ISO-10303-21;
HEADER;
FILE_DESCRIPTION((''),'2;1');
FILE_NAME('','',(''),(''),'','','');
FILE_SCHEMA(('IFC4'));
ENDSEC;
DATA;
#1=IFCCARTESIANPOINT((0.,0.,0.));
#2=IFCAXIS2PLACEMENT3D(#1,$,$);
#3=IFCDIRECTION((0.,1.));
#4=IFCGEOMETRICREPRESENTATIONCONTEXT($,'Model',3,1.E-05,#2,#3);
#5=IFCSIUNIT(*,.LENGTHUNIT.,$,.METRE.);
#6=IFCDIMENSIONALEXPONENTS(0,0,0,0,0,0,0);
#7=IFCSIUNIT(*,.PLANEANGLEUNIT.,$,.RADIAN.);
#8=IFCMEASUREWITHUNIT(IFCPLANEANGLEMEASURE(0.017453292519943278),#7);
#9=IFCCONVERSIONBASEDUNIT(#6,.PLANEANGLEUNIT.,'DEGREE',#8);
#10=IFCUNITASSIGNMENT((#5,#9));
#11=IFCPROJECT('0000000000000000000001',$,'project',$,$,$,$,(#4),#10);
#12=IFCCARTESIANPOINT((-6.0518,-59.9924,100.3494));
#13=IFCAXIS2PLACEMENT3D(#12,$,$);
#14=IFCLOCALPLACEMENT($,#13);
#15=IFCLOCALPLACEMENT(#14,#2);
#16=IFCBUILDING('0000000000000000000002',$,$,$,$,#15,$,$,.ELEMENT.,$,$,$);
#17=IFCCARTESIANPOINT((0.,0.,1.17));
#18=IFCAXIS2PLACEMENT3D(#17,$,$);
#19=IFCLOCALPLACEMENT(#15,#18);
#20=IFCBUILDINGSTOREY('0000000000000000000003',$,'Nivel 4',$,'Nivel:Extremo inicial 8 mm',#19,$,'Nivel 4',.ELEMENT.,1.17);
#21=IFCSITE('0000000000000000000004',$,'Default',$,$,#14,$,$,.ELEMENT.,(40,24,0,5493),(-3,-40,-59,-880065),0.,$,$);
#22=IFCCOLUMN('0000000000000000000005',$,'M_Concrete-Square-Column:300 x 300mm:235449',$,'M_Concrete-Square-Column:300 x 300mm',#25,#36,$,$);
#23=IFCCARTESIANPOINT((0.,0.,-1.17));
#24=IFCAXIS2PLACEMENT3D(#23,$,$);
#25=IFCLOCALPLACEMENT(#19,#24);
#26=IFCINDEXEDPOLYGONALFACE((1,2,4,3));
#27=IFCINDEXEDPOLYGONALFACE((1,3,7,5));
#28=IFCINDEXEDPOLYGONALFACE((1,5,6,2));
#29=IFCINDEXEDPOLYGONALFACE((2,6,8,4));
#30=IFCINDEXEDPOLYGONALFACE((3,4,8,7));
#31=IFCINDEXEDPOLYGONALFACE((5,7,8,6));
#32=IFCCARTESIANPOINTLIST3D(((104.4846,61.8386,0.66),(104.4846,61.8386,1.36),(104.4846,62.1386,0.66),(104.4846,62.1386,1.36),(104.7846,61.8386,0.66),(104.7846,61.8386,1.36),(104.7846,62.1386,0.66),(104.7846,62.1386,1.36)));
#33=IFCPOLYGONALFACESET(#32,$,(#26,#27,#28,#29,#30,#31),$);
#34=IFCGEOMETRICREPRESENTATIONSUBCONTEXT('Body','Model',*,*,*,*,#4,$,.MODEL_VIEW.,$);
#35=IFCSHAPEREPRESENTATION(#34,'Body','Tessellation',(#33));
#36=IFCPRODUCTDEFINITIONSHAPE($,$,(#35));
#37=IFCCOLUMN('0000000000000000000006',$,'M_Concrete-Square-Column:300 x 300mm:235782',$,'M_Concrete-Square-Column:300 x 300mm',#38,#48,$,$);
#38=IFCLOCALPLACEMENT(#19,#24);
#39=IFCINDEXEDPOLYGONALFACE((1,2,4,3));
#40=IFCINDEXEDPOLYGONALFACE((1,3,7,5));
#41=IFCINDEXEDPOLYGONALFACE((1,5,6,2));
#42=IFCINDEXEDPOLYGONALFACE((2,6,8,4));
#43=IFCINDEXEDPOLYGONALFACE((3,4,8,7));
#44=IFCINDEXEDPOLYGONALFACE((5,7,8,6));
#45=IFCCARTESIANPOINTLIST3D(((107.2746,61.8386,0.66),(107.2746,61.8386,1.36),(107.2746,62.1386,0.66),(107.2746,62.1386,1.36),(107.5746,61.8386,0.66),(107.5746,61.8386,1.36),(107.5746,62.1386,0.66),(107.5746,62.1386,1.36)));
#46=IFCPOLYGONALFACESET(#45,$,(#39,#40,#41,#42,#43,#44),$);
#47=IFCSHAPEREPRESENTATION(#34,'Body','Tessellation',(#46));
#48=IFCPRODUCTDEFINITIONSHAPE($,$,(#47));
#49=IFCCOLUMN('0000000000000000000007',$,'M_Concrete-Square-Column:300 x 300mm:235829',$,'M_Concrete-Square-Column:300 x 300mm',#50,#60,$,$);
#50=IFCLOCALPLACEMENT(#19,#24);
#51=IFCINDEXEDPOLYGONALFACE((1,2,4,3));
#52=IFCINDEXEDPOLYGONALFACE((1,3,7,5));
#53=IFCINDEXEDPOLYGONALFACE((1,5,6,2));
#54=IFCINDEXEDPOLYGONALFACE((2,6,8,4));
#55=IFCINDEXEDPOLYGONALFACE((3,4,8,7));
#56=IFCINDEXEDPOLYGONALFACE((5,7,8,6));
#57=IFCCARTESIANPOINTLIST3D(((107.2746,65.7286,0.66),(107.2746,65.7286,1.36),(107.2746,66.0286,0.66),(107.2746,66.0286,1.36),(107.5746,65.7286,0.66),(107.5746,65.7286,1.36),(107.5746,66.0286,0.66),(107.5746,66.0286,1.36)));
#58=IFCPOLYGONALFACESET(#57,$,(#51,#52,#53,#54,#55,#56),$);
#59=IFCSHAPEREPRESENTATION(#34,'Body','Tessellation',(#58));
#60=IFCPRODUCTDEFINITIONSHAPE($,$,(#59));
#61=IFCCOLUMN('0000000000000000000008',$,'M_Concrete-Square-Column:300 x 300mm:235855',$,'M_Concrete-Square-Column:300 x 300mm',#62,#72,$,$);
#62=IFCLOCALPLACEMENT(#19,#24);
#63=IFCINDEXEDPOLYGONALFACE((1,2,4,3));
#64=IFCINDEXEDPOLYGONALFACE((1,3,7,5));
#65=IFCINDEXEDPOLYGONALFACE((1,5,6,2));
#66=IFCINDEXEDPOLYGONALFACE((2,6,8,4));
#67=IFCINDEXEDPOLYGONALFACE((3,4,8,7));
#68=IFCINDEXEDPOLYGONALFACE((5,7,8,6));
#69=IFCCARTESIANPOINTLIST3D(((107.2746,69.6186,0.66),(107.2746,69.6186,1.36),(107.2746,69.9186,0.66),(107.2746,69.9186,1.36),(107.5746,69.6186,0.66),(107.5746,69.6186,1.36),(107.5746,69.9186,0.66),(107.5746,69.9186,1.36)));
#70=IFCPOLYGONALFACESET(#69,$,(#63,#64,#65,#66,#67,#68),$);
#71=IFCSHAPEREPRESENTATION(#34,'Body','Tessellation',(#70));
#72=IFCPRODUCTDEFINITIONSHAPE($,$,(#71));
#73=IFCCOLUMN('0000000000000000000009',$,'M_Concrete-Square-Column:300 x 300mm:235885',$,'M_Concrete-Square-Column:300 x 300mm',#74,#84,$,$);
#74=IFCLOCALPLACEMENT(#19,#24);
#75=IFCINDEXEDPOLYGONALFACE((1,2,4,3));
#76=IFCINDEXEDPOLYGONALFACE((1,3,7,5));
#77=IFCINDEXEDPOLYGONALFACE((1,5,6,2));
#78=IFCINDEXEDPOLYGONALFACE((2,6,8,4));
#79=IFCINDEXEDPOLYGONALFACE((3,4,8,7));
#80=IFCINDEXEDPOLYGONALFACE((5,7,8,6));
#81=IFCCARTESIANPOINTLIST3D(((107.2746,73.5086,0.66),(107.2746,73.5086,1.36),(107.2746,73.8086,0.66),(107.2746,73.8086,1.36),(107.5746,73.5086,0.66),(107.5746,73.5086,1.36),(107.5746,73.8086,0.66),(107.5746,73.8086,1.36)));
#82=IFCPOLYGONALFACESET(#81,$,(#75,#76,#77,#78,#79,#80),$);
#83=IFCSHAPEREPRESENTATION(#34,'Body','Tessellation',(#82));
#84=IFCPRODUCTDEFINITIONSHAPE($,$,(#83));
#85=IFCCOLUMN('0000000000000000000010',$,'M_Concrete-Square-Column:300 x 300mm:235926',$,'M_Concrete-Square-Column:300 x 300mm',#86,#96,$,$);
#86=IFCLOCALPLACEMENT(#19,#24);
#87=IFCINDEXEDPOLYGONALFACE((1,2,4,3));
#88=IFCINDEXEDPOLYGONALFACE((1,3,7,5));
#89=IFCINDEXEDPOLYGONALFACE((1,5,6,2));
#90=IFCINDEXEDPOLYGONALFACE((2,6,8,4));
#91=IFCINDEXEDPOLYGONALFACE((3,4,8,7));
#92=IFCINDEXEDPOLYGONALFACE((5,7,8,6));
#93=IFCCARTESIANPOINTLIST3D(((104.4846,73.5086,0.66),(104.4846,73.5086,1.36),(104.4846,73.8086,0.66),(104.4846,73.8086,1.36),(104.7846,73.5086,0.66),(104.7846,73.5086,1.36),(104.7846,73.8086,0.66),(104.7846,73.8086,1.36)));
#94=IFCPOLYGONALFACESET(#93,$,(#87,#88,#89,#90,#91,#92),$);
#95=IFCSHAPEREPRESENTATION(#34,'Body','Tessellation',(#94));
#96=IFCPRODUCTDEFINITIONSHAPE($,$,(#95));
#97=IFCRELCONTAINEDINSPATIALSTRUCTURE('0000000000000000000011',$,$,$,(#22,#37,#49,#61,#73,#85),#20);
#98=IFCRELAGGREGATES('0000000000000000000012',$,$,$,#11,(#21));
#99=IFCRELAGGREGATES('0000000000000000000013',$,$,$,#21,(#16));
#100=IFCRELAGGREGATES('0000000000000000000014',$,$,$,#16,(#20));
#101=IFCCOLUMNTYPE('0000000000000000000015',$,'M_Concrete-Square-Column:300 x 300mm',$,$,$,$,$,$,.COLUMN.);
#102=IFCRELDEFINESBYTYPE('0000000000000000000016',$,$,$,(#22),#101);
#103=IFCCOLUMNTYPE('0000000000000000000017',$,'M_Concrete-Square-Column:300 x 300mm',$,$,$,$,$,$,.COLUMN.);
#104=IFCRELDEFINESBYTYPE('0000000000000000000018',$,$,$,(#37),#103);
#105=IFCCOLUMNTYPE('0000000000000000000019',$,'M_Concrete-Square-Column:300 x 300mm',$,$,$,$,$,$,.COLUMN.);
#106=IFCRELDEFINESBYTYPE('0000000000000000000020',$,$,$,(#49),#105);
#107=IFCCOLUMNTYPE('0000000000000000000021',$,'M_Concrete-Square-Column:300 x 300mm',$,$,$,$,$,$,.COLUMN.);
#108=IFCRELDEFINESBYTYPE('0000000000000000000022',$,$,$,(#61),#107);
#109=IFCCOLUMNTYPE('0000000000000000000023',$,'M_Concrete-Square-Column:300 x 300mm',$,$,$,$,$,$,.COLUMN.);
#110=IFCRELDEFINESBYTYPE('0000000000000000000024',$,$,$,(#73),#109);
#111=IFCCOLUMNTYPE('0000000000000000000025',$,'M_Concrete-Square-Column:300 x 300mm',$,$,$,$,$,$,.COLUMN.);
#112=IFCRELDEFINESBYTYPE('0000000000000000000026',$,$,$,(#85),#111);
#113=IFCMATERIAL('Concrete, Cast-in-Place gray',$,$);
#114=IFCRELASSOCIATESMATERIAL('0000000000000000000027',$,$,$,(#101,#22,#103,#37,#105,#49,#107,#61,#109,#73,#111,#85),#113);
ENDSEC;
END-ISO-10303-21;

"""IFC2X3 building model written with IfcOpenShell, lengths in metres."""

from ifc_helpers import new_model, entity, si_unit, converted_unit, direction, frame, origin, origin_2d_with_axis, place, context, subcontext, project, spatial, rectangle, extrude, source, transform, mapped, material, type_object, type_shapes, element, save


model = new_model("IFC2X3")

# Units and contexts
model_context = context("Model", 3, precision=1e-05, world=origin(), true_north=direction((0.0, 1.0)))
body_context = subcontext(model_context, "Body", "Model", "MODEL_VIEW")
ifc_project = project(units=[si_unit("LENGTHUNIT", "METRE"), converted_unit("PLANEANGLEUNIT", "DEGREE", entity("IfcPlaneAngleMeasure", 0.017453292519943278), si_unit("PLANEANGLEUNIT", "RADIAN"), dimensions=[0, 0, 0, 0, 0, 0, 0])], contexts=[model_context])

# Site, building, storey
site_placement = place(None, frame((-6.0518, -59.9924, 100.3494)))
site = spatial("IfcSite", under=ifc_project, at=site_placement, Name="Default", CompositionType="ELEMENT", RefLatitude=(40, 24, 0, 5493), RefLongitude=(-3, -40, -59, -880065), RefElevation=0.0)
building_placement = place(site_placement, origin())
building = spatial("IfcBuilding", under=site, at=building_placement, CompositionType="ELEMENT")
storey_placement = place(building_placement, frame((0.0, 0.0, 1.17)))
storey = spatial("IfcBuildingStorey", under=building, at=storey_placement, Name="Nivel 4", ObjectType="Nivel:Extremo inicial 8 mm", LongName="Nivel 4", CompositionType="ELEMENT", Elevation=1.17)

# Columns
ifc_material_1 = material(Name="Concrete, Cast-in-Place gray")
column_type_1 = type_object("IfcColumnType", Name="M_Concrete-Square-Column:300 x 300mm", PredefinedType="COLUMN", material=ifc_material_1)
shared_shape_1 = source(origin(), body_context, "Body", "SweptSolid", [
    extrude(rectangle(XDim=0.3, YDim=0.3, at=origin_2d_with_axis()), frame((104.6346, 61.9886, 0.66), z_axis=(0.0, 0.0, 1.0), x_axis=(-1.0, 0.0, 0.0)), (0.0, 0.0, 1.0), 0.7),
])
type_shapes(column_type_1, [shared_shape_1])
column_1_placement = place(storey_placement, frame((0.0, 0.0, -1.17)))
element("IfcColumn", 1, at=column_1_placement, inside=storey, type_object=column_type_1, material=ifc_material_1, Name="M_Concrete-Square-Column:300 x 300mm:235449", ObjectType="M_Concrete-Square-Column:300 x 300mm", context=body_context, shape_type="MappedRepresentation", body=[
    mapped(shared_shape_1, transform((0.0, 0.0, 0.0), scale=1.0)),
])
column_type_2 = type_object("IfcColumnType", Name="M_Concrete-Square-Column:300 x 300mm", PredefinedType="COLUMN", material=ifc_material_1)
shared_shape_2 = source(origin(), body_context, "Body", "SweptSolid", [
    extrude(rectangle(XDim=0.3, YDim=0.3, at=origin_2d_with_axis()), frame((107.4246, 61.9886, 0.66), z_axis=(0.0, 0.0, 1.0), x_axis=(-1.0, 0.0, 0.0)), (0.0, 0.0, 1.0), 0.7),
])
type_shapes(column_type_2, [shared_shape_2])
column_2_placement = place(storey_placement, frame((0.0, 0.0, -1.17)))
element("IfcColumn", 2, at=column_2_placement, inside=storey, type_object=column_type_2, material=ifc_material_1, Name="M_Concrete-Square-Column:300 x 300mm:235782", ObjectType="M_Concrete-Square-Column:300 x 300mm", context=body_context, shape_type="MappedRepresentation", body=[
    mapped(shared_shape_2, transform((0.0, 0.0, 0.0), scale=1.0)),
])
column_type_3 = type_object("IfcColumnType", Name="M_Concrete-Square-Column:300 x 300mm", PredefinedType="COLUMN", material=ifc_material_1)
shared_shape_3 = source(origin(), body_context, "Body", "SweptSolid", [
    extrude(rectangle(XDim=0.3, YDim=0.3, at=origin_2d_with_axis()), frame((107.4246, 65.8786, 0.66), z_axis=(0.0, 0.0, 1.0), x_axis=(-1.0, 0.0, 0.0)), (0.0, 0.0, 1.0), 0.7),
])
type_shapes(column_type_3, [shared_shape_3])
column_3_placement = place(storey_placement, frame((0.0, 0.0, -1.17)))
element("IfcColumn", 3, at=column_3_placement, inside=storey, type_object=column_type_3, material=ifc_material_1, Name="M_Concrete-Square-Column:300 x 300mm:235829", ObjectType="M_Concrete-Square-Column:300 x 300mm", context=body_context, shape_type="MappedRepresentation", body=[
    mapped(shared_shape_3, transform((0.0, 0.0, 0.0), scale=1.0)),
])
column_type_4 = type_object("IfcColumnType", Name="M_Concrete-Square-Column:300 x 300mm", PredefinedType="COLUMN", material=ifc_material_1)
shared_shape_4 = source(origin(), body_context, "Body", "SweptSolid", [
    extrude(rectangle(XDim=0.3, YDim=0.3, at=origin_2d_with_axis()), frame((107.4246, 69.7686, 0.66), z_axis=(0.0, 0.0, 1.0), x_axis=(-1.0, 0.0, 0.0)), (0.0, 0.0, 1.0), 0.7),
])
type_shapes(column_type_4, [shared_shape_4])
column_4_placement = place(storey_placement, frame((0.0, 0.0, -1.17)))
element("IfcColumn", 4, at=column_4_placement, inside=storey, type_object=column_type_4, material=ifc_material_1, Name="M_Concrete-Square-Column:300 x 300mm:235855", ObjectType="M_Concrete-Square-Column:300 x 300mm", context=body_context, shape_type="MappedRepresentation", body=[
    mapped(shared_shape_4, transform((0.0, 0.0, 0.0), scale=1.0)),
])
column_type_5 = type_object("IfcColumnType", Name="M_Concrete-Square-Column:300 x 300mm", PredefinedType="COLUMN", material=ifc_material_1)
shared_shape_5 = source(origin(), body_context, "Body", "SweptSolid", [
    extrude(rectangle(XDim=0.3, YDim=0.3, at=origin_2d_with_axis()), frame((107.4246, 73.6586, 0.66), z_axis=(0.0, 0.0, 1.0), x_axis=(-1.0, 0.0, 0.0)), (0.0, 0.0, 1.0), 0.7),
])
type_shapes(column_type_5, [shared_shape_5])
column_5_placement = place(storey_placement, frame((0.0, 0.0, -1.17)))
element("IfcColumn", 5, at=column_5_placement, inside=storey, type_object=column_type_5, material=ifc_material_1, Name="M_Concrete-Square-Column:300 x 300mm:235885", ObjectType="M_Concrete-Square-Column:300 x 300mm", context=body_context, shape_type="MappedRepresentation", body=[
    mapped(shared_shape_5, transform((0.0, 0.0, 0.0), scale=1.0)),
])
column_type_6 = type_object("IfcColumnType", Name="M_Concrete-Square-Column:300 x 300mm", PredefinedType="COLUMN", material=ifc_material_1)
shared_shape_6 = source(origin(), body_context, "Body", "SweptSolid", [
    extrude(rectangle(XDim=0.3, YDim=0.3, at=origin_2d_with_axis()), frame((104.6346, 73.6586, 0.66), z_axis=(0.0, 0.0, 1.0), x_axis=(-1.0, 0.0, 0.0)), (0.0, 0.0, 1.0), 0.7),
])
type_shapes(column_type_6, [shared_shape_6])
column_6_placement = place(storey_placement, frame((0.0, 0.0, -1.17)))
element("IfcColumn", 6, at=column_6_placement, inside=storey, type_object=column_type_6, material=ifc_material_1, Name="M_Concrete-Square-Column:300 x 300mm:235926", ObjectType="M_Concrete-Square-Column:300 x 300mm", context=body_context, shape_type="MappedRepresentation", body=[
    mapped(shared_shape_6, transform((0.0, 0.0, 0.0), scale=1.0)),
])

save(model, "model.ifc")
